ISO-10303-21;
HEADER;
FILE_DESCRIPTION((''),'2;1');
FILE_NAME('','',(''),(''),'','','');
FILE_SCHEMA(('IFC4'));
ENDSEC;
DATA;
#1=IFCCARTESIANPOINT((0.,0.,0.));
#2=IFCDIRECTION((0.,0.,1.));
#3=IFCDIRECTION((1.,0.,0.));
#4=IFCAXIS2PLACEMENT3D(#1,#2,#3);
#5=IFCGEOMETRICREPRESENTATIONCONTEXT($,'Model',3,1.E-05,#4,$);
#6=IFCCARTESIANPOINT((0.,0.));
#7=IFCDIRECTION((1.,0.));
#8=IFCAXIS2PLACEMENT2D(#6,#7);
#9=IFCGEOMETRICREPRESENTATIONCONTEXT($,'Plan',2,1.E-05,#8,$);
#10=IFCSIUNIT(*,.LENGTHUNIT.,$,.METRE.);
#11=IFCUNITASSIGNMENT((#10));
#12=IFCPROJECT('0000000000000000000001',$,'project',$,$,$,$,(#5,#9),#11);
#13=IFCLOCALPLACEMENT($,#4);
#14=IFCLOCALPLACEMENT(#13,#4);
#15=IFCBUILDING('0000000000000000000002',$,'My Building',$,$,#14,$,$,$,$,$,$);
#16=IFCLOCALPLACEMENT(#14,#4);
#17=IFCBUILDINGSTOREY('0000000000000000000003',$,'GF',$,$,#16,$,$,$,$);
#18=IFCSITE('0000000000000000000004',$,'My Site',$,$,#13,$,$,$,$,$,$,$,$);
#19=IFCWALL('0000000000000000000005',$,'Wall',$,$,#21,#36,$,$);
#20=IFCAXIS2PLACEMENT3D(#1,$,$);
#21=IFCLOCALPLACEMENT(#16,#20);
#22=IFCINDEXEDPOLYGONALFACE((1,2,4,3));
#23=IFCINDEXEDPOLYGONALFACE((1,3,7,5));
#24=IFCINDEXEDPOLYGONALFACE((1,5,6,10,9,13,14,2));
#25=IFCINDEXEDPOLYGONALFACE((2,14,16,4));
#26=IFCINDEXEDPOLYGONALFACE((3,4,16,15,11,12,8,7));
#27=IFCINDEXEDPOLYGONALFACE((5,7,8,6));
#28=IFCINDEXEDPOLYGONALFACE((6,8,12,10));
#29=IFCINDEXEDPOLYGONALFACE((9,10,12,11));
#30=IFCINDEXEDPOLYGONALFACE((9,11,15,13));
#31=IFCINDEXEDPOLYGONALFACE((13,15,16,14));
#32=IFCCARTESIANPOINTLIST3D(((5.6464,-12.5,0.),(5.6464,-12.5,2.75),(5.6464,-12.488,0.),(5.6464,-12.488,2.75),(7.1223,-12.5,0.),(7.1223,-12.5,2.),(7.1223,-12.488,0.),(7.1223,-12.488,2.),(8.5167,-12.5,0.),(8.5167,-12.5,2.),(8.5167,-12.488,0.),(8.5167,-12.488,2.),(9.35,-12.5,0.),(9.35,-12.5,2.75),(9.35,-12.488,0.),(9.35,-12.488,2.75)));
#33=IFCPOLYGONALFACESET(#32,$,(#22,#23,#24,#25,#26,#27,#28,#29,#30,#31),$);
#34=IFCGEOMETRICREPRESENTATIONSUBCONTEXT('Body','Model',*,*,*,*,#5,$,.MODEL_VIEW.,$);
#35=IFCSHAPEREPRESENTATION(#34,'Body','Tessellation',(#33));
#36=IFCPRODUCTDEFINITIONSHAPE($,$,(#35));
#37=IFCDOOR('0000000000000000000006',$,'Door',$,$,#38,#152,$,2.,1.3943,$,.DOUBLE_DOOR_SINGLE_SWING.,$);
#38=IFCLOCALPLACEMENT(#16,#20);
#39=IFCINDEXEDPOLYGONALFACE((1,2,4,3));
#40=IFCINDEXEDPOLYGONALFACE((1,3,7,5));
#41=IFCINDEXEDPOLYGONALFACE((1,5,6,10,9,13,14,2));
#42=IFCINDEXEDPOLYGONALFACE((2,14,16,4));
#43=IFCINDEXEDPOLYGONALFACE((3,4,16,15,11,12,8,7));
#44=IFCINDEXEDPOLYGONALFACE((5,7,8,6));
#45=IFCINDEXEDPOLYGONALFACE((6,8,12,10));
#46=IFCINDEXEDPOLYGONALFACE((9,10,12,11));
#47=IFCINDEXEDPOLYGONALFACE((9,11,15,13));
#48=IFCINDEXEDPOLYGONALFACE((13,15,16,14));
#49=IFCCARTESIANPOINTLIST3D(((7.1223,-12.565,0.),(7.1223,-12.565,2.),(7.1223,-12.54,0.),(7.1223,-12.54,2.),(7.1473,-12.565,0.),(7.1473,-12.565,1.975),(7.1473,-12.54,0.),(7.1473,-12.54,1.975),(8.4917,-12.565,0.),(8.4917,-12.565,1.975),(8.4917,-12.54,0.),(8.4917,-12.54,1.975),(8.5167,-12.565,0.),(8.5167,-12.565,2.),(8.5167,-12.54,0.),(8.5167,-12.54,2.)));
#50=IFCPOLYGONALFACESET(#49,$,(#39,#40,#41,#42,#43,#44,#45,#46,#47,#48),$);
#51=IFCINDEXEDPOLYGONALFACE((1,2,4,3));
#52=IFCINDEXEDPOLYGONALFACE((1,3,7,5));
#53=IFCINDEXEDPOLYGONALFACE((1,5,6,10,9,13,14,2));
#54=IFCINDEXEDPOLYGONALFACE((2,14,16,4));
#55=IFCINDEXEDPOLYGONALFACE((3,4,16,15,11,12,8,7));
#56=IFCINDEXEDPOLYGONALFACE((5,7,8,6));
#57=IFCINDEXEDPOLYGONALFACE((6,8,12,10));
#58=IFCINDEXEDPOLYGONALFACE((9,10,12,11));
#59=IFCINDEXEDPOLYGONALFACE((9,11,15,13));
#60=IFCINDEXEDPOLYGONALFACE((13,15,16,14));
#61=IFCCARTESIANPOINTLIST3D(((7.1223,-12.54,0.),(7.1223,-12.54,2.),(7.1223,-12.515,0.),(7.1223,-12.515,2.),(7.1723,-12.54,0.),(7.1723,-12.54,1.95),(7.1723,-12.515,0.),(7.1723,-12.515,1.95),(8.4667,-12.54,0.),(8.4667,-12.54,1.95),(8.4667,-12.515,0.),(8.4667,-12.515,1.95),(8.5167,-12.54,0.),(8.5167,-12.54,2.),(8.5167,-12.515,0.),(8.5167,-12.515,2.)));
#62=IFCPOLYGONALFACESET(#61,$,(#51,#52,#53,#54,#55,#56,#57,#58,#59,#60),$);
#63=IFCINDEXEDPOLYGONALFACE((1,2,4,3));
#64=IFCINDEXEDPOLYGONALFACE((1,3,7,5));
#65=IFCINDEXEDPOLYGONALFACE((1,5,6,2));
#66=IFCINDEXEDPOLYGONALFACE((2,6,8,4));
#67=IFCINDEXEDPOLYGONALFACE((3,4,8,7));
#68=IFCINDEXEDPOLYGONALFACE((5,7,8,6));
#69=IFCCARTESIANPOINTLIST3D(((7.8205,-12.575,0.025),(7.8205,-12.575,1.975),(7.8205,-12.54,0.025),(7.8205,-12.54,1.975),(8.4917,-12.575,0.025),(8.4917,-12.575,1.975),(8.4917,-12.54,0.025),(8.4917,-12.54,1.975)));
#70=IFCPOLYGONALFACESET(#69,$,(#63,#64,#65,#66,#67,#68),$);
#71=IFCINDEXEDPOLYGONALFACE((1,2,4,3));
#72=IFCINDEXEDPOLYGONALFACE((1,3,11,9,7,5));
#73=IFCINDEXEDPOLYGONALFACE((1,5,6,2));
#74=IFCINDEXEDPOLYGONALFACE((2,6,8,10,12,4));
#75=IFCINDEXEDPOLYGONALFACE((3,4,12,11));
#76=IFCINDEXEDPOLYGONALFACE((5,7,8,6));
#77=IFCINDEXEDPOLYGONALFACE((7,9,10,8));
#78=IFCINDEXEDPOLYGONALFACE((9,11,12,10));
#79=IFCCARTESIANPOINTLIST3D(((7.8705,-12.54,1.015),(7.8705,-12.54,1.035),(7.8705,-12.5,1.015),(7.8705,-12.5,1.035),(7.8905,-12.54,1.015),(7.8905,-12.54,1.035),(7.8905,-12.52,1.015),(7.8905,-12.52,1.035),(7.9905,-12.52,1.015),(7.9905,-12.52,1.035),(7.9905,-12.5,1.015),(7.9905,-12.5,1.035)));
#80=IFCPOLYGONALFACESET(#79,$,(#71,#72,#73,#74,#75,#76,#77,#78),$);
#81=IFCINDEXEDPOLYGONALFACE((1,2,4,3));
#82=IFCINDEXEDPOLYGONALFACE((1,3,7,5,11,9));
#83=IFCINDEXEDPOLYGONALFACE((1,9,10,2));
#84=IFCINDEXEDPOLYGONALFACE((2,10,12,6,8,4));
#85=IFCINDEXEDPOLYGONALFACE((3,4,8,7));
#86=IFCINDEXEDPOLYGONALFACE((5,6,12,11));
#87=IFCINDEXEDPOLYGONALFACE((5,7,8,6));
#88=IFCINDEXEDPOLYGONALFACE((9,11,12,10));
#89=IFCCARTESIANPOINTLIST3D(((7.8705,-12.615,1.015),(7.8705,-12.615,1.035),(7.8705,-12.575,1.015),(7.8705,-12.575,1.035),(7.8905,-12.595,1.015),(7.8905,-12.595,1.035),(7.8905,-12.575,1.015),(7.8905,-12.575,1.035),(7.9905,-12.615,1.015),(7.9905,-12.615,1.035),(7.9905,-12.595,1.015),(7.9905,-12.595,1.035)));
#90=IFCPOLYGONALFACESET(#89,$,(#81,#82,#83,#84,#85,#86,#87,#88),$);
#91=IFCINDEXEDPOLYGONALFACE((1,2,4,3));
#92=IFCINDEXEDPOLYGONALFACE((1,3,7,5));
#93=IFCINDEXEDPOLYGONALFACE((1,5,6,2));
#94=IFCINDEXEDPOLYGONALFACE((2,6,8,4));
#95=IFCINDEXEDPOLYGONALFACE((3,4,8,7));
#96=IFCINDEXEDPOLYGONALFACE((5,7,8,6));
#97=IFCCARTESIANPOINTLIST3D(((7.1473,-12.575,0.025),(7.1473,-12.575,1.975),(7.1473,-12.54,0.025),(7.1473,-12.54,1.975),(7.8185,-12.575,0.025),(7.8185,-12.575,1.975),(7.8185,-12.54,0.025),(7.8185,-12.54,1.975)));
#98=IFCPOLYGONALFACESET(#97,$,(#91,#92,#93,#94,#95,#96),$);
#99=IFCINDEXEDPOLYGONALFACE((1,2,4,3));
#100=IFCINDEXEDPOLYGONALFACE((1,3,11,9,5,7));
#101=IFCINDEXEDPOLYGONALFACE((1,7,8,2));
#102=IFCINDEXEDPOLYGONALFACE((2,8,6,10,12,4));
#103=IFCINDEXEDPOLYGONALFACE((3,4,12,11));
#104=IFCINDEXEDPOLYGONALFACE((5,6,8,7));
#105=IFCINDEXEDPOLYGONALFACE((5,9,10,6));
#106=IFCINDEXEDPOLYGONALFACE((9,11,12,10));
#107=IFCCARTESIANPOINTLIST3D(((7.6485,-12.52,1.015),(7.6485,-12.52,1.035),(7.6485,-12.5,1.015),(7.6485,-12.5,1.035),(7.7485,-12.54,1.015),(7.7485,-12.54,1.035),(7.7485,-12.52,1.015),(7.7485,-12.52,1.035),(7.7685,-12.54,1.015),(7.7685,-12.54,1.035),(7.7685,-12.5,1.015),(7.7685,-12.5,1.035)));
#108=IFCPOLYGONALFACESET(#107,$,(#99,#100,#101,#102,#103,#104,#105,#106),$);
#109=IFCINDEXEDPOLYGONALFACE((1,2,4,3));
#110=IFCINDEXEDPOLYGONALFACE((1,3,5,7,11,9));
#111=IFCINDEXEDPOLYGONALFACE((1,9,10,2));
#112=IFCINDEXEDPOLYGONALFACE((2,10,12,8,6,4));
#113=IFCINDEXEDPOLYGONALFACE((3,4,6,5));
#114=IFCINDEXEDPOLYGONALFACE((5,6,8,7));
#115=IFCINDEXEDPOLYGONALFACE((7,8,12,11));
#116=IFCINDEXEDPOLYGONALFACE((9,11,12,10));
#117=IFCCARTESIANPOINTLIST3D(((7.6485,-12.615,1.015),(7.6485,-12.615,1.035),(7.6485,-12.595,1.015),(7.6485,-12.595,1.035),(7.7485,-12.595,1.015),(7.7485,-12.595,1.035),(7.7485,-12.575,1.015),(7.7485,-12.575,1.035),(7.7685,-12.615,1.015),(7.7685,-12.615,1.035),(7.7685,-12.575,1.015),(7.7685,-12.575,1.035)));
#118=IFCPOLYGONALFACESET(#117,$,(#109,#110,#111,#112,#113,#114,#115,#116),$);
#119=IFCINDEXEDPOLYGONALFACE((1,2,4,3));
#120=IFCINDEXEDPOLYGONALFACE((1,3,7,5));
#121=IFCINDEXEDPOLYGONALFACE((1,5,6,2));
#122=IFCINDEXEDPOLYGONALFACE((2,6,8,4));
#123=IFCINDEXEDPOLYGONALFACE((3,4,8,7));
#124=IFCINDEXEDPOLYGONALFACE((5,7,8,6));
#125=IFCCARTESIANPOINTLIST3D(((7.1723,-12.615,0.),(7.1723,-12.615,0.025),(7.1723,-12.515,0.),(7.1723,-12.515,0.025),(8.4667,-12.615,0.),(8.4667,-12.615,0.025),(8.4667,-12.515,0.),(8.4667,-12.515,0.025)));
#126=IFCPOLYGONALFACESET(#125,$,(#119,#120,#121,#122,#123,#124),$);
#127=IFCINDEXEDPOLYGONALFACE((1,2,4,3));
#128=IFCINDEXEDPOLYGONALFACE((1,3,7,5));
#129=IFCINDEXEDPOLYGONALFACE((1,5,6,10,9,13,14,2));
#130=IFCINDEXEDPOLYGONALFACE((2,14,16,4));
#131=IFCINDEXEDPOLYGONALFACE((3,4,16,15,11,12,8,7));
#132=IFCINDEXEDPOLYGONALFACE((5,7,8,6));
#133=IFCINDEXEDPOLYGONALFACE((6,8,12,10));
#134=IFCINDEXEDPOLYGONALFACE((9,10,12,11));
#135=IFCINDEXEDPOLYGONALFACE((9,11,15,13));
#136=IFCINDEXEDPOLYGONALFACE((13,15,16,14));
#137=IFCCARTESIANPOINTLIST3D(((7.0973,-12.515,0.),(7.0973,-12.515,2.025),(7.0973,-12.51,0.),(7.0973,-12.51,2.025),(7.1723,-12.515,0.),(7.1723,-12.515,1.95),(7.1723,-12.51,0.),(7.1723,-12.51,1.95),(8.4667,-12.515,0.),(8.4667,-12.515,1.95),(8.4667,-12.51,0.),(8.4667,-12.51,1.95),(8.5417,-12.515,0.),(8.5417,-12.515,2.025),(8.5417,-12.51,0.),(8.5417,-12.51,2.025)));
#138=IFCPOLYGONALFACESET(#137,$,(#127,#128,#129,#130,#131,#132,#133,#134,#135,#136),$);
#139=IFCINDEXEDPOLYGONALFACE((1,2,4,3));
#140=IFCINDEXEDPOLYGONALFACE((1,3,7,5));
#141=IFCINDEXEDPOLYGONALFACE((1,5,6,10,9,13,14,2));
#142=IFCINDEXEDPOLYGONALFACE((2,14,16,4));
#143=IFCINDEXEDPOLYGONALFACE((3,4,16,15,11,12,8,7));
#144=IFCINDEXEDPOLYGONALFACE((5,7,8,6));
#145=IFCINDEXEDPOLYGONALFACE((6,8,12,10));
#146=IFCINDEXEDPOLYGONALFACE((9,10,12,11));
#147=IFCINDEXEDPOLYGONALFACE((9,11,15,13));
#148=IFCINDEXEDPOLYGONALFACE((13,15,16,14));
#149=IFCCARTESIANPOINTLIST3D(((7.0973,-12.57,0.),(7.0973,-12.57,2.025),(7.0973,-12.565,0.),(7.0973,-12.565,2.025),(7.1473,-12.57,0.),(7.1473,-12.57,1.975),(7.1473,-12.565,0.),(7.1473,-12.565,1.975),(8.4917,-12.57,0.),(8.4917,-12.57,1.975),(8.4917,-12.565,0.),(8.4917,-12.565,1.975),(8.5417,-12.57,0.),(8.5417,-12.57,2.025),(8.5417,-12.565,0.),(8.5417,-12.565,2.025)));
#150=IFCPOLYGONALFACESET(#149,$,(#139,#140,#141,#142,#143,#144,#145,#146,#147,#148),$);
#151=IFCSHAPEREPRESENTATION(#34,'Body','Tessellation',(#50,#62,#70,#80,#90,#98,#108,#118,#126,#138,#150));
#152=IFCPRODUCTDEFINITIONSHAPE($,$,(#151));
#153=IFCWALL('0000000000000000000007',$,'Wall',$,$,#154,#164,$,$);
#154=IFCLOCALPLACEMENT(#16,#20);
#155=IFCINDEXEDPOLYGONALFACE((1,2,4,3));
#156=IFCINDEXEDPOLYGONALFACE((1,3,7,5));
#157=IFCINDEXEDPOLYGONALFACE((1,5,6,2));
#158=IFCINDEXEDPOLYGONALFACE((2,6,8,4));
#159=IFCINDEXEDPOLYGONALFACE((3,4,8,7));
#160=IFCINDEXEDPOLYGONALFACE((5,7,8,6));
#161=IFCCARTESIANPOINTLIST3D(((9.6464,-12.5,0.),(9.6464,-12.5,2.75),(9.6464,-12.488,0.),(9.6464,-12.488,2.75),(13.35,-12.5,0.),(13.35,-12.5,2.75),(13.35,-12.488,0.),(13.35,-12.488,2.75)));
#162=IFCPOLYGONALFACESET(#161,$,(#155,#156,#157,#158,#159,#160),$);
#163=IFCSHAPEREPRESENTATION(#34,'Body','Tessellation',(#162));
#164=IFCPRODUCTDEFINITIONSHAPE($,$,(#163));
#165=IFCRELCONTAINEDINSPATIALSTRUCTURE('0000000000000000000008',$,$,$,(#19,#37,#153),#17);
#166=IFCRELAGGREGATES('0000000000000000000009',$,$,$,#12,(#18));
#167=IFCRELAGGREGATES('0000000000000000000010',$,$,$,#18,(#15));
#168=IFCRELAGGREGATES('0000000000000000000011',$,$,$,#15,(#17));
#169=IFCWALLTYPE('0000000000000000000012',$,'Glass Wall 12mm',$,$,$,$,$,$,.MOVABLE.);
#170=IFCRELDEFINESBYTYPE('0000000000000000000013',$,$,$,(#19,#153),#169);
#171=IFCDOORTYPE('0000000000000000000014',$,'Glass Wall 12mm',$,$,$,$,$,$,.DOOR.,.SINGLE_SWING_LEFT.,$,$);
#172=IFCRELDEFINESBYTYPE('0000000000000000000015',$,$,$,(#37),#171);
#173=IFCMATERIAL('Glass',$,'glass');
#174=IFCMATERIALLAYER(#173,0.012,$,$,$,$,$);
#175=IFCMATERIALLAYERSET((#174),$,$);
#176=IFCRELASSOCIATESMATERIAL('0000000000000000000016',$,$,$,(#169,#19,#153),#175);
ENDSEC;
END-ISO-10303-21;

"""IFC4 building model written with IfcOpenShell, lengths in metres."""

from ifc_helpers import new_model, entity, si_unit, frame, origin_with_axes, origin_2d_with_axis, place, context, subcontext, project, spatial, line, indexed_curve, outline, extrude, shape, source, transform, mapped, material, layer, layer_set, layer_usage, type_object, type_shapes, element, fill, save


model = new_model("IFC4")

# Units and contexts
model_context = context("Model", 3, precision=1e-05, world=origin_with_axes())
plan_context = context("Plan", 2, precision=1e-05, world=origin_2d_with_axis())
body_context_1 = subcontext(model_context, "Body", "Model", "MODEL_VIEW")
body_context_2 = subcontext(plan_context, "Body", "Plan", "PLAN_VIEW")
ifc_project = project(units=[si_unit("LENGTHUNIT", "METRE")], contexts=[model_context, plan_context])

# Site, building, storey
site_placement = place(None, origin_with_axes())
site = spatial("IfcSite", under=ifc_project, at=site_placement, Name="My Site")
building_placement = place(site_placement, origin_with_axes())
building = spatial("IfcBuilding", under=site, at=building_placement, Name="My Building")
storey_placement = place(building_placement, origin_with_axes())
storey = spatial("IfcBuildingStorey", under=building, at=storey_placement, Name="GF")

# Wall, opening, door
ifc_material_1 = material(Name="Glass", Category="glass")
ifc_layer_1 = layer(ifc_material_1, 0.012)
ifc_layer_set_1 = layer_set([ifc_layer_1])
ifc_layer_usage_1 = layer_usage(ifc_layer_set_1, "AXIS2", "POSITIVE", 0.0)
wall_type_1 = type_object("IfcWallType", Name="Glass Wall 12mm", PredefinedType="MOVABLE", material=ifc_layer_set_1)
wall_1_placement = place(storey_placement, frame((5.6464, -12.5, 0.0), z_axis=(0.0, 0.0, 1.0), x_axis=(1.0, 0.0, 0.0)))
wall_1 = element("IfcWall", 1, at=wall_1_placement, inside=storey, type_object=wall_type_1, material=ifc_layer_usage_1, Name="Wall", context=body_context_1, shape_type="SweptSolid", body=[
    extrude(outline(indexed_curve([(0.0, 0.0), (0.0, 0.012), (3.7036, 0.012), (3.7036, 0.0)], segments=[line(1, 2, 3, 4, 1)])), origin_with_axes(), (0.0, 0.0, 1.0), 2.75),
])
shared_shape_1 = source(origin_with_axes(), body_context_1, "Body", "SweptSolid", [
    extrude(outline(indexed_curve([(0.0, 0.0), (1.3943, 0.0), (1.3943, 2.0), (0.0, 2.0)], segments=[line(1, 2, 3, 4, 1)])), frame((0.0, -0.6, 0.0), z_axis=(0.0, -1.0, 0.0), x_axis=(1.0, 0.0, 0.0)), (0.0, 0.0, -1.0), 1.2),
])
opening_1_placement = place(wall_1_placement, frame((2.8703, -0.015, 0.0), z_axis=(0.0, 0.0, 1.0), x_axis=(-1.0, 0.0, 0.0)))
opening_1 = element("IfcOpeningElement", 2, at=opening_1_placement, cuts=wall_1, PredefinedType="OPENING", context=body_context_1, shape_type="MappedRepresentation", body=[
    mapped(shared_shape_1, transform((0.0, 0.0, 0.0), x_axis=(1.0, 0.0, 0.0), y_axis=(0.0, 1.0, 0.0), z_axis=(0.0, 0.0, 1.0), scale=1.0)),
])
door_type = type_object("IfcDoorType", Name="Glass Wall 12mm", OperationType="SINGLE_SWING_LEFT", PredefinedType="DOOR")
shared_shape_2 = source(origin_with_axes(), body_context_1, "Body", "SweptSolid", [
    extrude(outline(indexed_curve([(0.0, 0.0), (0.0, 2.0), (1.3943, 2.0), (1.3943, 0.0), (1.3693, 0.0), (1.3693, 1.975), (0.025, 1.975), (0.025, 0.0)], segments=[line(1, 2, 3, 4, 5, 6, 7, 8, 1)])), frame((0.0, 0.025, 0.0), z_axis=(0.0, -1.0, 0.0), x_axis=(1.0, 0.0, 0.0)), (0.0, 0.0, -1.0), 0.025),
    extrude(outline(indexed_curve([(0.0, 0.0), (0.0, 2.0), (1.3943, 2.0), (1.3943, 0.0), (1.3443, 0.0), (1.3443, 1.95), (0.05, 1.95), (0.05, 0.0)], segments=[line(1, 2, 3, 4, 5, 6, 7, 8, 1)])), frame((0.0, 0.0, 0.0), z_axis=(0.0, -1.0, 0.0), x_axis=(1.0, 0.0, 0.0)), (0.0, 0.0, -1.0), 0.025),
    extrude(outline(indexed_curve([(0.0, 0.0), (0.6712, 0.0), (0.6712, 0.035), (0.0, 0.035)], segments=[line(1, 2, 3, 4, 1)])), frame((0.025, 0.025, 0.025), z_axis=(0.0, 0.0, 1.0), x_axis=(1.0, 0.0, 0.0)), (0.0, 0.0, 1.0), 1.95),
    extrude(outline(indexed_curve([(0.0, 0.0), (0.0, -0.04), (-0.12, -0.04), (-0.12, -0.02), (-0.02, -0.02), (-0.02, 0.0)], segments=[line(1, 2, 3, 4, 5, 6, 1)])), frame((0.6462, 0.025, 1.015), z_axis=(0.0, 0.0, 1.0), x_axis=(1.0, 0.0, 0.0)), (0.0, 0.0, 1.0), 0.02),
    extrude(outline(indexed_curve([(0.0, 0.0), (0.0, 0.04), (-0.12, 0.04), (-0.12, 0.02), (-0.02, 0.02), (-0.02, 0.0)], segments=[line(1, 2, 3, 4, 5, 6, 1)])), frame((0.6462, 0.06, 1.015), z_axis=(0.0, 0.0, 1.0), x_axis=(1.0, 0.0, 0.0)), (0.0, 0.0, 1.0), 0.02),
    extrude(outline(indexed_curve([(0.0, 0.0), (-0.6712, 0.0), (-0.6712, 0.035), (0.0, 0.035)], segments=[line(1, 2, 3, 4, 1)])), frame((1.3693, 0.025, 0.025), z_axis=(0.0, 0.0, 1.0), x_axis=(1.0, 0.0, 0.0)), (0.0, 0.0, 1.0), 1.95),
    extrude(outline(indexed_curve([(0.0, 0.0), (0.0, -0.04), (0.12, -0.04), (0.12, -0.02), (0.02, -0.02), (0.02, 0.0)], segments=[line(1, 2, 3, 4, 5, 6, 1)])), frame((0.7482, 0.025, 1.015), z_axis=(0.0, 0.0, 1.0), x_axis=(1.0, 0.0, 0.0)), (0.0, 0.0, 1.0), 0.02),
    extrude(outline(indexed_curve([(0.0, 0.0), (0.0, 0.04), (0.12, 0.04), (0.12, 0.02), (0.02, 0.02), (0.02, 0.0)], segments=[line(1, 2, 3, 4, 5, 6, 1)])), frame((0.7482, 0.06, 1.015), z_axis=(0.0, 0.0, 1.0), x_axis=(1.0, 0.0, 0.0)), (0.0, 0.0, 1.0), 0.02),
    extrude(outline(indexed_curve([(0.0, 0.0), (1.2943, 0.0), (1.2943, 0.1), (0.0, 0.1)], segments=[line(1, 2, 3, 4, 1)])), frame((0.05, 0.0, 0.0), z_axis=(0.0, 0.0, 1.0), x_axis=(1.0, 0.0, 0.0)), (0.0, 0.0, 1.0), 0.025),
    extrude(outline(indexed_curve([(0.0, 0.0), (0.0, 2.025), (1.4443, 2.025), (1.4443, 0.0), (1.3693, 0.0), (1.3693, 1.95), (0.075, 1.95), (0.075, 0.0)], segments=[line(1, 2, 3, 4, 5, 6, 7, 8, 1)])), frame((-0.025, -0.005, 0.0), z_axis=(0.0, -1.0, 0.0), x_axis=(1.0, 0.0, 0.0)), (0.0, 0.0, -1.0), 0.005),
    extrude(outline(indexed_curve([(0.0, 0.0), (0.0, 2.025), (1.4443, 2.025), (1.4443, 0.0), (1.3943, 0.0), (1.3943, 1.975), (0.05, 1.975), (0.05, 0.0)], segments=[line(1, 2, 3, 4, 5, 6, 7, 8, 1)])), frame((-0.025, 0.05, 0.0), z_axis=(0.0, -1.0, 0.0), x_axis=(1.0, 0.0, 0.0)), (0.0, 0.0, -1.0), 0.005),
])
shared_shape_3 = source(origin_with_axes(), body_context_2, "Body", "Curve2D", [
    entity("IfcIndexedPolyCurve", entity("IfcCartesianPointList2D", [[0.0, 0.0], [0.0, 0.05], [0.025, 0.05], [0.025, 0.025], [0.05, 0.025], [0.05, 0.0]]), [entity("IfcLineIndex", [1, 2, 3, 4, 5, 6, 1])]),
    entity("IfcIndexedPolyCurve", entity("IfcCartesianPointList2D", [[1.3943, 0.0], [1.3943, 0.05], [1.3693, 0.05], [1.3693, 0.025], [1.3443, 0.025], [1.3443, 0.0]]), [entity("IfcLineIndex", [1, 2, 3, 4, 5, 6, 1])]),
    entity("IfcTrimmedCurve", entity("IfcEllipse", entity("IfcAxis2Placement2D", entity("IfcCartesianPoint", [0.06, 0.05]), entity("IfcDirection", [1.0, 0.0])), 0.6372, 0.6722), [entity("IfcCartesianPoint", [0.6972, 0.05])], [entity("IfcCartesianPoint", [0.06, 0.7222])], True, "CARTESIAN"),
    entity("IfcIndexedPolyCurve", entity("IfcCartesianPointList2D", [[0.025, 0.05], [0.06, 0.05], [0.06, 0.7222], [0.025, 0.7222]]), [entity("IfcLineIndex", [1, 2, 3, 4, 1])]),
    entity("IfcTrimmedCurve", entity("IfcEllipse", entity("IfcAxis2Placement2D", entity("IfcCartesianPoint", [1.3343, 0.05]), entity("IfcDirection", [1.0, 0.0])), 0.6372, 0.6722), [entity("IfcCartesianPoint", [1.3343, 0.7222])], [entity("IfcCartesianPoint", [0.6972, 0.05])], True, "CARTESIAN"),
    entity("IfcIndexedPolyCurve", entity("IfcCartesianPointList2D", [[1.3693, 0.05], [1.3343, 0.05], [1.3343, 0.7222], [1.3693, 0.7222]]), [entity("IfcLineIndex", [1, 2, 3, 4, 1])]),
])
type_shapes(door_type, [shared_shape_2, shared_shape_3])
door_placement = place(opening_1_placement, frame((0.0, 0.0, 0.0), z_axis=(0.0, 0.0, 1.0), x_axis=(1.0, 0.0, 0.0)))
door = element("IfcDoor", 3, at=door_placement, inside=storey, type_object=door_type, Name="Door", OperationType="DOUBLE_DOOR_SINGLE_SWING", OverallHeight=2.0, OverallWidth=1.3943, shapes=[
    shape(body_context_1, "Body", "MappedRepresentation", [mapped(shared_shape_2, transform((0.0, 0.0, 0.0), x_axis=(1.0, 0.0, 0.0), y_axis=(0.0, 1.0, 0.0), z_axis=(0.0, 0.0, 1.0), scale=1.0))]),
    shape(body_context_2, "Body", "MappedRepresentation", [mapped(shared_shape_3, transform((0.0, 0.0, 0.0), x_axis=(1.0, 0.0, 0.0), y_axis=(0.0, 1.0, 0.0), z_axis=(0.0, 0.0, 1.0), scale=1.0))]),
])
fill(opening_1, door)

# Wall
ifc_layer_usage_2 = layer_usage(ifc_layer_set_1, "AXIS2", "POSITIVE", 0.0)
wall_2_placement = place(storey_placement, frame((9.6464, -12.5, 0.0), z_axis=(0.0, 0.0, 1.0), x_axis=(1.0, 0.0, 0.0)))
element("IfcWall", 4, at=wall_2_placement, inside=storey, type_object=wall_type_1, material=ifc_layer_usage_2, Name="Wall", context=body_context_1, shape_type="SweptSolid", body=[
    extrude(outline(indexed_curve([(0.0, 0.0), (0.0, 0.012), (3.7036, 0.012), (3.7036, 0.0)], segments=[line(1, 2, 3, 4, 1)])), origin_with_axes(), (0.0, 0.0, 1.0), 2.75),
])

save(model, "model.ifc")
